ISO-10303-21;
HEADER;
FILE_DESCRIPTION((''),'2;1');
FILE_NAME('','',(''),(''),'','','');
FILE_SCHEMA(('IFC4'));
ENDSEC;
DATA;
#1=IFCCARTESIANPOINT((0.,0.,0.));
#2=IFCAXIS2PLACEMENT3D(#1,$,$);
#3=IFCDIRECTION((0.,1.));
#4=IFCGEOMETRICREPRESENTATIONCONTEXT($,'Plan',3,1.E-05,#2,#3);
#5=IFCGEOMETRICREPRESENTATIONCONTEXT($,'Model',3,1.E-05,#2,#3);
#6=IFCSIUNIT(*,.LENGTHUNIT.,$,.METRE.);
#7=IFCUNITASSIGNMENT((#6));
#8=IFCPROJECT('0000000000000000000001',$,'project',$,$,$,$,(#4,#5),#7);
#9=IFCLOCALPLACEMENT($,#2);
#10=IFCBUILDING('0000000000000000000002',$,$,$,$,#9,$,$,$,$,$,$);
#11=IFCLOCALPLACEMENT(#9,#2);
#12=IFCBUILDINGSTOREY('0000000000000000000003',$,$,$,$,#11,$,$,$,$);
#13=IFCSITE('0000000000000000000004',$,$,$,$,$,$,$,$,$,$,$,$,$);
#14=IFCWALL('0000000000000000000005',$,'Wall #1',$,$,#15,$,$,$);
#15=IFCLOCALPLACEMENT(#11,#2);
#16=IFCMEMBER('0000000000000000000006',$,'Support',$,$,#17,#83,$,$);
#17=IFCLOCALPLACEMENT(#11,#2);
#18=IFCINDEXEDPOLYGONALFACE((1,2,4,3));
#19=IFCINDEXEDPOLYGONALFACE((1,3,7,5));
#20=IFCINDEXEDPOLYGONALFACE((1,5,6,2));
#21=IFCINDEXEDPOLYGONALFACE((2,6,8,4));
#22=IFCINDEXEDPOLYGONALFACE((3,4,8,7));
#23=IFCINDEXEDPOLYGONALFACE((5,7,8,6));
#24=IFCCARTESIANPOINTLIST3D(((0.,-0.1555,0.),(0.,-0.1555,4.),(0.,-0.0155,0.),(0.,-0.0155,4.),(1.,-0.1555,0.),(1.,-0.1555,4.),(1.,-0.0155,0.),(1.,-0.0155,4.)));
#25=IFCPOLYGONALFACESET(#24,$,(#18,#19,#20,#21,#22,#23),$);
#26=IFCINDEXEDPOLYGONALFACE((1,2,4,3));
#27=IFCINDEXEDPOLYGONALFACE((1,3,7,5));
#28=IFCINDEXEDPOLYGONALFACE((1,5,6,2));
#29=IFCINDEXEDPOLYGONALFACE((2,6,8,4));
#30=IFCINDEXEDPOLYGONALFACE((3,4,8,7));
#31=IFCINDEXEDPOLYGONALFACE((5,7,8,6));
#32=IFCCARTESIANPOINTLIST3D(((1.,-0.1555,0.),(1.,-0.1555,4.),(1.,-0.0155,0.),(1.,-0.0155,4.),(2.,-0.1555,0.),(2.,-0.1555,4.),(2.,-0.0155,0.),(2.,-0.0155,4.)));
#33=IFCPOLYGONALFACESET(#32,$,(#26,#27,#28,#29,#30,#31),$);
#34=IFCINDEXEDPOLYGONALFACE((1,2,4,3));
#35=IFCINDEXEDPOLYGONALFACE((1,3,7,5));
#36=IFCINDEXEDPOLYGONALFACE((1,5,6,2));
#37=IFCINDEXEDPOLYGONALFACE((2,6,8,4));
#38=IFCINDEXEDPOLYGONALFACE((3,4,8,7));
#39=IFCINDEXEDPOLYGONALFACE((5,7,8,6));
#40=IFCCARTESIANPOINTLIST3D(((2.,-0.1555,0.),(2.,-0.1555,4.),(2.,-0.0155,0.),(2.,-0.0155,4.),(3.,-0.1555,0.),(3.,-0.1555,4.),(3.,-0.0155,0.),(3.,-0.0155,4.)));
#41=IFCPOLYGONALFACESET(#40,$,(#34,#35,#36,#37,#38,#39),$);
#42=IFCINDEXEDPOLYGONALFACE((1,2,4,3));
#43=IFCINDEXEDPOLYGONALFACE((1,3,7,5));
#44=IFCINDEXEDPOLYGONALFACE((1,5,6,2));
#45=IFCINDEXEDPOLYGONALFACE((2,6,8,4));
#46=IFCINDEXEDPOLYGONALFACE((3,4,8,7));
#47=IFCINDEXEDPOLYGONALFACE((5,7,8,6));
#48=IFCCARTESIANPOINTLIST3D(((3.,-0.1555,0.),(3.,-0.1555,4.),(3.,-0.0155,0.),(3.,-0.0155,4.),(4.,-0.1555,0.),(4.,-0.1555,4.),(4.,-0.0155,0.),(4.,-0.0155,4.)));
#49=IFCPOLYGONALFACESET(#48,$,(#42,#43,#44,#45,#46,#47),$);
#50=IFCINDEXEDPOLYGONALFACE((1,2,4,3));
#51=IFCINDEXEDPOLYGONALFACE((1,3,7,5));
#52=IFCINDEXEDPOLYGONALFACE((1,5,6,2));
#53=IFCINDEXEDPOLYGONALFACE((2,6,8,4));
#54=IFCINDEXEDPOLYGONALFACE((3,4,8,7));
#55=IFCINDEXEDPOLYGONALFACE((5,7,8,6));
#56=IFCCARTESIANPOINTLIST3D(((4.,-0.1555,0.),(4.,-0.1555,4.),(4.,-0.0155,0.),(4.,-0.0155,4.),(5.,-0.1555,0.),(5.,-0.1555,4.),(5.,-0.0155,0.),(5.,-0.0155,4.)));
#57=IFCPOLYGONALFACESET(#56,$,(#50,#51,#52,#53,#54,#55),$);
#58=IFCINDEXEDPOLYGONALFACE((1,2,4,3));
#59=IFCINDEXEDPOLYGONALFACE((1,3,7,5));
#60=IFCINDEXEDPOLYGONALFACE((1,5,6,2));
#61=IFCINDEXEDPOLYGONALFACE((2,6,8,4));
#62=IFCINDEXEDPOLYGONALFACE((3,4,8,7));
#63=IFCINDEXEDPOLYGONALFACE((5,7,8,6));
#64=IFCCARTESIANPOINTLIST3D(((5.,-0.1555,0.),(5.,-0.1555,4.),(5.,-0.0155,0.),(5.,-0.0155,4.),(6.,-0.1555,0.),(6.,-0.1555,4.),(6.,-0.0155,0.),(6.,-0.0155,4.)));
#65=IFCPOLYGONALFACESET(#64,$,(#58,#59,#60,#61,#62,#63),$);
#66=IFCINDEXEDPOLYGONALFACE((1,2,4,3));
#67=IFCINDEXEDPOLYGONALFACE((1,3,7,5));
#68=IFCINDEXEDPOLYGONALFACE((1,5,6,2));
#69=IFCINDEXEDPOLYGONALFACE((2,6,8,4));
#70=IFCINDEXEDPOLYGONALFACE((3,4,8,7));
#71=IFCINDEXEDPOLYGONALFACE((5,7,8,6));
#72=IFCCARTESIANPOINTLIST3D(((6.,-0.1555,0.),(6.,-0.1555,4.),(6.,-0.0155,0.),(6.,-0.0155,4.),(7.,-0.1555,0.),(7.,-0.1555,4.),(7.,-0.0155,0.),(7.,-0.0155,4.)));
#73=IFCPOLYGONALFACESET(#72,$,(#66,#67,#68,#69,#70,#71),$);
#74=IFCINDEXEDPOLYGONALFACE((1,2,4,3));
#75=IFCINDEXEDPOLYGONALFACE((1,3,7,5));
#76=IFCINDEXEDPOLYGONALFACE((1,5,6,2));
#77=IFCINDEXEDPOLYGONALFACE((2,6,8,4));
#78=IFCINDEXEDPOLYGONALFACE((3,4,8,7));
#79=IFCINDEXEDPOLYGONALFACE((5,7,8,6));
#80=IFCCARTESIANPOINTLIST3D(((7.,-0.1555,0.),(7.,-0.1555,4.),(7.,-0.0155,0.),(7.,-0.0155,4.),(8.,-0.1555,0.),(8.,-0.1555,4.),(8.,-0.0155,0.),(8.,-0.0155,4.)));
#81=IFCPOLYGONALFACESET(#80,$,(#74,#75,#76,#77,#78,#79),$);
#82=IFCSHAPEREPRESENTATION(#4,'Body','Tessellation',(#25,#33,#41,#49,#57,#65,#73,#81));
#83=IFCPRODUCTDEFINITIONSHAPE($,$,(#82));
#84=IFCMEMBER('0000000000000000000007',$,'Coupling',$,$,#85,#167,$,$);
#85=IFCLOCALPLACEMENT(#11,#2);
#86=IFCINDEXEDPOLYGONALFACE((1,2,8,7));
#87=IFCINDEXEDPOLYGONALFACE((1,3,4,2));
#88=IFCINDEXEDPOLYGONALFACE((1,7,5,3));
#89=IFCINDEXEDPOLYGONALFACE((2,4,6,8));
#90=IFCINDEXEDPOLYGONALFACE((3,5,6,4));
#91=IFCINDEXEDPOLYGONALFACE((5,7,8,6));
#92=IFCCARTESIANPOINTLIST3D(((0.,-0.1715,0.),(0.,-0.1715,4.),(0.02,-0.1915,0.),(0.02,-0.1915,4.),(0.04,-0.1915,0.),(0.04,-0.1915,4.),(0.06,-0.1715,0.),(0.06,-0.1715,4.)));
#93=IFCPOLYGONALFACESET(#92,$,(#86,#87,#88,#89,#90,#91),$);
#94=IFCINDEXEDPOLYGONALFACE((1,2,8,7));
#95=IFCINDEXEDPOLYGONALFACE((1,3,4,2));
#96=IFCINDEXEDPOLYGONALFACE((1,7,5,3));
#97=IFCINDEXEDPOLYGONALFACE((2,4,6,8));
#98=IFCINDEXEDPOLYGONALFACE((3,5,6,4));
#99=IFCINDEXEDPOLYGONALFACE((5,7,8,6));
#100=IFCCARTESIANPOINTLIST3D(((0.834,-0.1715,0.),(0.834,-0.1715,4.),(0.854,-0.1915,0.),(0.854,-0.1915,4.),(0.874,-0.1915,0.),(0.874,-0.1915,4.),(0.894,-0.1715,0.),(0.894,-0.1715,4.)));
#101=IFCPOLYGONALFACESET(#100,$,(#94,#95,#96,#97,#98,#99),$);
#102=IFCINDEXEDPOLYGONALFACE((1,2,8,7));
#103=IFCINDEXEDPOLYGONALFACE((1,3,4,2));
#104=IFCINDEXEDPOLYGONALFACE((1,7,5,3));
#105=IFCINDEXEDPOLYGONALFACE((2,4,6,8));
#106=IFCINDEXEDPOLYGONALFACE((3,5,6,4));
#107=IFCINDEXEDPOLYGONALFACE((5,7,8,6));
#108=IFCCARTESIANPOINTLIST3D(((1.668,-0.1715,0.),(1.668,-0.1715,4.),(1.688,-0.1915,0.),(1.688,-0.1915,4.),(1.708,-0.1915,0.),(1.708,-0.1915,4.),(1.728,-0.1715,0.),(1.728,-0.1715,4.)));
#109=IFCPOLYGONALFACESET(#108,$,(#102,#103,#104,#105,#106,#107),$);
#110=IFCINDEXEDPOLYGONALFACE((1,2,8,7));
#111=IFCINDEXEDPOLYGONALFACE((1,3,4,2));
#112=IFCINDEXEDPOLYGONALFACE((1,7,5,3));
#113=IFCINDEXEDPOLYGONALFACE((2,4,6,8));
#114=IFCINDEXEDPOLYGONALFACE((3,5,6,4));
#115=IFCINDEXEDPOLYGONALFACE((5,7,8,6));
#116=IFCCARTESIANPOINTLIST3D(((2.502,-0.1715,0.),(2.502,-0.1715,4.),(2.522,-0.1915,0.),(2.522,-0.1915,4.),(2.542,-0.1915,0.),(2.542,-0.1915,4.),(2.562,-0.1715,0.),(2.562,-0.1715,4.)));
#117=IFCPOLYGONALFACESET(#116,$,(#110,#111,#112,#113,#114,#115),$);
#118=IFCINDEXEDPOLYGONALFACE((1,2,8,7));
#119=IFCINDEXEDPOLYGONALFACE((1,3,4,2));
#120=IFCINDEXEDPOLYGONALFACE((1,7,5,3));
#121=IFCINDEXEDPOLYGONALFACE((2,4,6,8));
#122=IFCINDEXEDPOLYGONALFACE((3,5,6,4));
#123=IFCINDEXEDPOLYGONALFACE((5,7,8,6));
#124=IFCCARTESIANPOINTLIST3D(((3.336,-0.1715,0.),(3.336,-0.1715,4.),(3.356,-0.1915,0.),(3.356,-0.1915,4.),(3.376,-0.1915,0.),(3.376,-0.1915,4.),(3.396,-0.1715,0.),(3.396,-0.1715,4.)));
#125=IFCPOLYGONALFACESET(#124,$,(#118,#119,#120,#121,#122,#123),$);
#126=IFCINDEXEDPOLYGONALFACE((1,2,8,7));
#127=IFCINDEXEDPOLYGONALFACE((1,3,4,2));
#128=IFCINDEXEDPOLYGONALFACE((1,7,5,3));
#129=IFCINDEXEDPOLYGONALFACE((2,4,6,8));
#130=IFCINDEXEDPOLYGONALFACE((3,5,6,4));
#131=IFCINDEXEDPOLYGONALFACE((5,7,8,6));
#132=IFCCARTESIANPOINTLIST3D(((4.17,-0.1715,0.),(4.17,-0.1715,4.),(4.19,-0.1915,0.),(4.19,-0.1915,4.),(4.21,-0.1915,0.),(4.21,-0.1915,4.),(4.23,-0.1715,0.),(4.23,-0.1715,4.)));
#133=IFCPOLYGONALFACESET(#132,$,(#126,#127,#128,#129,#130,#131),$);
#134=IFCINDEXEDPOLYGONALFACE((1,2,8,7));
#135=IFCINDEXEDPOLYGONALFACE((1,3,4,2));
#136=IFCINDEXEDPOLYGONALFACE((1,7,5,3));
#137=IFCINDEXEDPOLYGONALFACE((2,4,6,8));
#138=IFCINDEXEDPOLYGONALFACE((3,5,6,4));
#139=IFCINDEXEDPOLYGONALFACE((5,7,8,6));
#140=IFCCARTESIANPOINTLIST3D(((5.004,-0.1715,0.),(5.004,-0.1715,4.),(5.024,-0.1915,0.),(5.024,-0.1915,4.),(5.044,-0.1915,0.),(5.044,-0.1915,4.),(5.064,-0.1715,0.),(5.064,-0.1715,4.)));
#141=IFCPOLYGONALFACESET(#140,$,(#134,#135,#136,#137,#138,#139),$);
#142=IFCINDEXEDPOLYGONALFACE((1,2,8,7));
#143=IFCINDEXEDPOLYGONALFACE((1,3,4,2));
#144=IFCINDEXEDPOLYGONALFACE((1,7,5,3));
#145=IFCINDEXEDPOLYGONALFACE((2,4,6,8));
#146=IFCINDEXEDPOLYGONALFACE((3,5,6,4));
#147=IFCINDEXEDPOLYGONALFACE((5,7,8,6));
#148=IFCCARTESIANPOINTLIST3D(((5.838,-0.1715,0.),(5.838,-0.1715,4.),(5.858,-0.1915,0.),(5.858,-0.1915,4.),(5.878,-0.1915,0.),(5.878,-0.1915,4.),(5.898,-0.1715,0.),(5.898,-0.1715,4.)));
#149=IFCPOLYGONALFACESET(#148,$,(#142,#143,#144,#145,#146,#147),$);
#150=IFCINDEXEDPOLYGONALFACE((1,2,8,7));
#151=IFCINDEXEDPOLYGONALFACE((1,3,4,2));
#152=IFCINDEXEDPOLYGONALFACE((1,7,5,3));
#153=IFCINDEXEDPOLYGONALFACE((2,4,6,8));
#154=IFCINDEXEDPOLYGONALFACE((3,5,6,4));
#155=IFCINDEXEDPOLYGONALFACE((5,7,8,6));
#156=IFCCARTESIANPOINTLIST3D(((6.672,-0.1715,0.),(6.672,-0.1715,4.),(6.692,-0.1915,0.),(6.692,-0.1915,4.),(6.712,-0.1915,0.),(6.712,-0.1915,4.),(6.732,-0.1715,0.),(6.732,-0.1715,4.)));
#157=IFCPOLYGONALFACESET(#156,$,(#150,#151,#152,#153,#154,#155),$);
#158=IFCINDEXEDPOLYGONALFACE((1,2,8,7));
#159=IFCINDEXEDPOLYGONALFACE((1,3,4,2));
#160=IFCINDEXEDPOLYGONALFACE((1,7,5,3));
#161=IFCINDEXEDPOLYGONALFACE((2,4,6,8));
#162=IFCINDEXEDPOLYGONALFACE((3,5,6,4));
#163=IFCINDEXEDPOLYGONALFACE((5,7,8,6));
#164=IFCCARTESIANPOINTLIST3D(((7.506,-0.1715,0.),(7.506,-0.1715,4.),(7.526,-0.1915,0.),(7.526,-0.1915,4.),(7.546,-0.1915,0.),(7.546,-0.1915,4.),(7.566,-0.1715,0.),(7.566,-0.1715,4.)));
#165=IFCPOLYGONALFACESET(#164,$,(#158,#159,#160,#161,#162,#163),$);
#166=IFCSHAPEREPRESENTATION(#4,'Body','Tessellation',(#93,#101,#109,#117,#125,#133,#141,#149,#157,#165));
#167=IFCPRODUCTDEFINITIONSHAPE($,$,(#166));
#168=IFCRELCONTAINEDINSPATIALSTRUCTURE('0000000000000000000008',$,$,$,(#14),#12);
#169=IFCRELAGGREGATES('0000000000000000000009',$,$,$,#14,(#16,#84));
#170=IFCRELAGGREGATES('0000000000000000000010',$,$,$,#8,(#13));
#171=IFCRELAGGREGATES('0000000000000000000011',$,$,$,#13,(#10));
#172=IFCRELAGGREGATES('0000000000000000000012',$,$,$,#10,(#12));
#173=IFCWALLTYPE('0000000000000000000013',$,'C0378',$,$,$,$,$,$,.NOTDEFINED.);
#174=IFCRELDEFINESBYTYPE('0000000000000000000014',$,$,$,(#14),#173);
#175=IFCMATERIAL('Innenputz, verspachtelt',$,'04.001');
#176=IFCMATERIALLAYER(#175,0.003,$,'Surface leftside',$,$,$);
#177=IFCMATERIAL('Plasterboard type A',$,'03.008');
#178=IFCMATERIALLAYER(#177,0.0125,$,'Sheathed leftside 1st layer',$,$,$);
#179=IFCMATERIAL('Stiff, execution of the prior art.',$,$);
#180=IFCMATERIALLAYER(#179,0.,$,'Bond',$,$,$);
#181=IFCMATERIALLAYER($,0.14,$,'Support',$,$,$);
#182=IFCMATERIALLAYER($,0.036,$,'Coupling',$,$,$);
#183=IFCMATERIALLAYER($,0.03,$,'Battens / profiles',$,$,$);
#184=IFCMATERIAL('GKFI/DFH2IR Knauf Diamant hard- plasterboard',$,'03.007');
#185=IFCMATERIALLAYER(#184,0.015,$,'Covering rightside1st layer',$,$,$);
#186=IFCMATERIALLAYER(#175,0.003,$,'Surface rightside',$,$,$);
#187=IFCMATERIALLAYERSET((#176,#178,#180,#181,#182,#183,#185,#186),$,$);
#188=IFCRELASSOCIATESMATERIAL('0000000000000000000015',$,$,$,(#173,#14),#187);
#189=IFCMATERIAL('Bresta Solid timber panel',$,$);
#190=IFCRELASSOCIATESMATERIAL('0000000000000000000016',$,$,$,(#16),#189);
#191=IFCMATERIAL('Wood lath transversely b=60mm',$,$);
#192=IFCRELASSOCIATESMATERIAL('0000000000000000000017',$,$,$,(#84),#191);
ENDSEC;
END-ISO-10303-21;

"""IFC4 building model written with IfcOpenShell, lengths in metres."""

from ifc_helpers import new_model, si_unit, direction, frame, frame_2d, origin, place, context, project, spatial, polyline, rectangle, outline, extrude, material, layer, layer_set, type_object, element, aggregate, save


model = new_model("IFC4")

# Units and contexts
plan_context = context("Plan", 3, precision=1e-05, world=origin(), true_north=direction((0.0, 1.0)))
model_context = context("Model", 3, precision=1e-05, world=origin(), true_north=direction((0.0, 1.0)))
ifc_project = project(units=[si_unit("LENGTHUNIT", "METRE")], contexts=[plan_context, model_context])

# Site, building, storey
site = spatial("IfcSite", under=ifc_project)
building_placement = place(None, origin())
building = spatial("IfcBuilding", under=site, at=building_placement)
storey_placement = place(building_placement, origin())
storey = spatial("IfcBuildingStorey", under=building, at=storey_placement)

# Wall, members
ifc_material_1 = material(Name="Innenputz, verspachtelt", Category="04.001")
ifc_layer_1 = layer(ifc_material_1, 0.003, Name="Surface leftside")
ifc_material_2 = material(Name="Plasterboard type A", Category="03.008")
ifc_layer_2 = layer(ifc_material_2, 0.0125, Name="Sheathed leftside 1st layer")
ifc_material_3 = material(Name="Stiff, execution of the prior art.")
ifc_layer_3 = layer(ifc_material_3, 0.0, Name="Bond")
ifc_layer_4 = layer(None, 0.14, Name="Support")
ifc_layer_5 = layer(None, 0.036, Name="Coupling")
ifc_layer_6 = layer(None, 0.03, Name="Battens / profiles")
ifc_material_4 = material(Name="GKFI/DFH2IR Knauf Diamant hard- plasterboard", Category="03.007")
ifc_layer_7 = layer(ifc_material_4, 0.015, Name="Covering rightside1st layer")
ifc_layer_8 = layer(ifc_material_1, 0.003, Name="Surface rightside")
ifc_layer_set = layer_set([ifc_layer_1, ifc_layer_2, ifc_layer_3, ifc_layer_4, ifc_layer_5, ifc_layer_6, ifc_layer_7, ifc_layer_8])
wall_type = type_object("IfcWallType", Name="C0378", PredefinedType="NOTDEFINED", material=ifc_layer_set)
wall_placement = place(None, frame((0.0, 0.0, 0.0), z_axis=(0.0, -1.0, 0.0), x_axis=(1.0, 0.0, 0.0)))
wall = element("IfcWall", 1, at=wall_placement, inside=storey, type_object=wall_type, material=ifc_layer_set, Name="Wall #1")
ifc_material_5 = material(Name="Bresta Solid timber panel")
member_1_placement = place(wall_placement, origin())
member_1 = element("IfcMember", 2, at=member_1_placement, material=ifc_material_5, Name="Support", context=plan_context, shape_type="SweptSolid", body=[
    extrude(rectangle(XDim=1.0, YDim=0.14, at=frame_2d((0.5, 0.07), x_axis=(1.0, 0.0))), frame((0.0, 4.0, 0.0155), z_axis=(0.0, -1.0, 0.0), x_axis=(1.0, 0.0, 0.0)), (0.0, 0.0, 1.0), 4.0),
    extrude(rectangle(XDim=1.0, YDim=0.14, at=frame_2d((0.5, 0.07), x_axis=(1.0, 0.0))), frame((1.0, 4.0, 0.0155), z_axis=(0.0, -1.0, 0.0), x_axis=(1.0, 0.0, 0.0)), (0.0, 0.0, 1.0), 4.0),
    extrude(rectangle(XDim=1.0, YDim=0.14, at=frame_2d((0.5, 0.07), x_axis=(1.0, 0.0))), frame((2.0, 4.0, 0.0155), z_axis=(0.0, -1.0, 0.0), x_axis=(1.0, 0.0, 0.0)), (0.0, 0.0, 1.0), 4.0),
    extrude(rectangle(XDim=1.0, YDim=0.14, at=frame_2d((0.5, 0.07), x_axis=(1.0, 0.0))), frame((3.0, 4.0, 0.0155), z_axis=(0.0, -1.0, 0.0), x_axis=(1.0, 0.0, 0.0)), (0.0, 0.0, 1.0), 4.0),
    extrude(rectangle(XDim=1.0, YDim=0.14, at=frame_2d((0.5, 0.07), x_axis=(1.0, 0.0))), frame((4.0, 4.0, 0.0155), z_axis=(0.0, -1.0, 0.0), x_axis=(1.0, 0.0, 0.0)), (0.0, 0.0, 1.0), 4.0),
    extrude(rectangle(XDim=1.0, YDim=0.14, at=frame_2d((0.5, 0.07), x_axis=(1.0, 0.0))), frame((5.0, 4.0, 0.0155), z_axis=(0.0, -1.0, 0.0), x_axis=(1.0, 0.0, 0.0)), (0.0, 0.0, 1.0), 4.0),
    extrude(rectangle(XDim=1.0, YDim=0.14, at=frame_2d((0.5, 0.07), x_axis=(1.0, 0.0))), frame((6.0, 4.0, 0.0155), z_axis=(0.0, -1.0, 0.0), x_axis=(1.0, 0.0, 0.0)), (0.0, 0.0, 1.0), 4.0),
    extrude(rectangle(XDim=1.0, YDim=0.14, at=frame_2d((0.5, 0.07), x_axis=(1.0, 0.0))), frame((7.0, 4.0, 0.0155), z_axis=(0.0, -1.0, 0.0), x_axis=(1.0, 0.0, 0.0)), (0.0, 0.0, 1.0), 4.0),
])
ifc_material_6 = material(Name="Wood lath transversely b=60mm")
member_2_placement = place(wall_placement, origin())
member_2 = element("IfcMember", 3, at=member_2_placement, material=ifc_material_6, Name="Coupling", context=plan_context, shape_type="SweptSolid", body=[
    extrude(outline(polyline([(0.0, 0.0), (0.06, 0.0), (0.04, 0.02), (0.02, 0.02), (0.0, 0.0)])), frame((0.0, 4.0, 0.1715), z_axis=(0.0, -1.0, 0.0), x_axis=(1.0, 0.0, 0.0)), (0.0, 0.0, 1.0), 4.0),
    extrude(outline(polyline([(0.0, 0.0), (0.06, 0.0), (0.04, 0.02), (0.02, 0.02), (0.0, 0.0)])), frame((0.834, 4.0, 0.1715), z_axis=(0.0, -1.0, 0.0), x_axis=(1.0, 0.0, 0.0)), (0.0, 0.0, 1.0), 4.0),
    extrude(outline(polyline([(0.0, 0.0), (0.06, 0.0), (0.04, 0.02), (0.02, 0.02), (0.0, 0.0)])), frame((1.668, 4.0, 0.1715), z_axis=(0.0, -1.0, 0.0), x_axis=(1.0, 0.0, 0.0)), (0.0, 0.0, 1.0), 4.0),
    extrude(outline(polyline([(0.0, 0.0), (0.06, 0.0), (0.04, 0.02), (0.02, 0.02), (0.0, 0.0)])), frame((2.502, 4.0, 0.1715), z_axis=(0.0, -1.0, 0.0), x_axis=(1.0, 0.0, 0.0)), (0.0, 0.0, 1.0), 4.0),
    extrude(outline(polyline([(0.0, 0.0), (0.06, 0.0), (0.04, 0.02), (0.02, 0.02), (0.0, 0.0)])), frame((3.336, 4.0, 0.1715), z_axis=(0.0, -1.0, 0.0), x_axis=(1.0, 0.0, 0.0)), (0.0, 0.0, 1.0), 4.0),
    extrude(outline(polyline([(0.0, 0.0), (0.06, 0.0), (0.04, 0.02), (0.02, 0.02), (0.0, 0.0)])), frame((4.17, 4.0, 0.1715), z_axis=(0.0, -1.0, 0.0), x_axis=(1.0, 0.0, 0.0)), (0.0, 0.0, 1.0), 4.0),
    extrude(outline(polyline([(0.0, 0.0), (0.06, 0.0), (0.04, 0.02), (0.02, 0.02), (0.0, 0.0)])), frame((5.004, 4.0, 0.1715), z_axis=(0.0, -1.0, 0.0), x_axis=(1.0, 0.0, 0.0)), (0.0, 0.0, 1.0), 4.0),
    extrude(outline(polyline([(0.0, 0.0), (0.06, 0.0), (0.04, 0.02), (0.02, 0.02), (0.0, 0.0)])), frame((5.838, 4.0, 0.1715), z_axis=(0.0, -1.0, 0.0), x_axis=(1.0, 0.0, 0.0)), (0.0, 0.0, 1.0), 4.0),
    extrude(outline(polyline([(0.0, 0.0), (0.06, 0.0), (0.04, 0.02), (0.02, 0.02), (0.0, 0.0)])), frame((6.672, 4.0, 0.1715), z_axis=(0.0, -1.0, 0.0), x_axis=(1.0, 0.0, 0.0)), (0.0, 0.0, 1.0), 4.0),
    extrude(outline(polyline([(0.0, 0.0), (0.06, 0.0), (0.04, 0.02), (0.02, 0.02), (0.0, 0.0)])), frame((7.506, 4.0, 0.1715), z_axis=(0.0, -1.0, 0.0), x_axis=(1.0, 0.0, 0.0)), (0.0, 0.0, 1.0), 4.0),
])
aggregate(wall, [member_1, member_2])

save(model, "model.ifc")
